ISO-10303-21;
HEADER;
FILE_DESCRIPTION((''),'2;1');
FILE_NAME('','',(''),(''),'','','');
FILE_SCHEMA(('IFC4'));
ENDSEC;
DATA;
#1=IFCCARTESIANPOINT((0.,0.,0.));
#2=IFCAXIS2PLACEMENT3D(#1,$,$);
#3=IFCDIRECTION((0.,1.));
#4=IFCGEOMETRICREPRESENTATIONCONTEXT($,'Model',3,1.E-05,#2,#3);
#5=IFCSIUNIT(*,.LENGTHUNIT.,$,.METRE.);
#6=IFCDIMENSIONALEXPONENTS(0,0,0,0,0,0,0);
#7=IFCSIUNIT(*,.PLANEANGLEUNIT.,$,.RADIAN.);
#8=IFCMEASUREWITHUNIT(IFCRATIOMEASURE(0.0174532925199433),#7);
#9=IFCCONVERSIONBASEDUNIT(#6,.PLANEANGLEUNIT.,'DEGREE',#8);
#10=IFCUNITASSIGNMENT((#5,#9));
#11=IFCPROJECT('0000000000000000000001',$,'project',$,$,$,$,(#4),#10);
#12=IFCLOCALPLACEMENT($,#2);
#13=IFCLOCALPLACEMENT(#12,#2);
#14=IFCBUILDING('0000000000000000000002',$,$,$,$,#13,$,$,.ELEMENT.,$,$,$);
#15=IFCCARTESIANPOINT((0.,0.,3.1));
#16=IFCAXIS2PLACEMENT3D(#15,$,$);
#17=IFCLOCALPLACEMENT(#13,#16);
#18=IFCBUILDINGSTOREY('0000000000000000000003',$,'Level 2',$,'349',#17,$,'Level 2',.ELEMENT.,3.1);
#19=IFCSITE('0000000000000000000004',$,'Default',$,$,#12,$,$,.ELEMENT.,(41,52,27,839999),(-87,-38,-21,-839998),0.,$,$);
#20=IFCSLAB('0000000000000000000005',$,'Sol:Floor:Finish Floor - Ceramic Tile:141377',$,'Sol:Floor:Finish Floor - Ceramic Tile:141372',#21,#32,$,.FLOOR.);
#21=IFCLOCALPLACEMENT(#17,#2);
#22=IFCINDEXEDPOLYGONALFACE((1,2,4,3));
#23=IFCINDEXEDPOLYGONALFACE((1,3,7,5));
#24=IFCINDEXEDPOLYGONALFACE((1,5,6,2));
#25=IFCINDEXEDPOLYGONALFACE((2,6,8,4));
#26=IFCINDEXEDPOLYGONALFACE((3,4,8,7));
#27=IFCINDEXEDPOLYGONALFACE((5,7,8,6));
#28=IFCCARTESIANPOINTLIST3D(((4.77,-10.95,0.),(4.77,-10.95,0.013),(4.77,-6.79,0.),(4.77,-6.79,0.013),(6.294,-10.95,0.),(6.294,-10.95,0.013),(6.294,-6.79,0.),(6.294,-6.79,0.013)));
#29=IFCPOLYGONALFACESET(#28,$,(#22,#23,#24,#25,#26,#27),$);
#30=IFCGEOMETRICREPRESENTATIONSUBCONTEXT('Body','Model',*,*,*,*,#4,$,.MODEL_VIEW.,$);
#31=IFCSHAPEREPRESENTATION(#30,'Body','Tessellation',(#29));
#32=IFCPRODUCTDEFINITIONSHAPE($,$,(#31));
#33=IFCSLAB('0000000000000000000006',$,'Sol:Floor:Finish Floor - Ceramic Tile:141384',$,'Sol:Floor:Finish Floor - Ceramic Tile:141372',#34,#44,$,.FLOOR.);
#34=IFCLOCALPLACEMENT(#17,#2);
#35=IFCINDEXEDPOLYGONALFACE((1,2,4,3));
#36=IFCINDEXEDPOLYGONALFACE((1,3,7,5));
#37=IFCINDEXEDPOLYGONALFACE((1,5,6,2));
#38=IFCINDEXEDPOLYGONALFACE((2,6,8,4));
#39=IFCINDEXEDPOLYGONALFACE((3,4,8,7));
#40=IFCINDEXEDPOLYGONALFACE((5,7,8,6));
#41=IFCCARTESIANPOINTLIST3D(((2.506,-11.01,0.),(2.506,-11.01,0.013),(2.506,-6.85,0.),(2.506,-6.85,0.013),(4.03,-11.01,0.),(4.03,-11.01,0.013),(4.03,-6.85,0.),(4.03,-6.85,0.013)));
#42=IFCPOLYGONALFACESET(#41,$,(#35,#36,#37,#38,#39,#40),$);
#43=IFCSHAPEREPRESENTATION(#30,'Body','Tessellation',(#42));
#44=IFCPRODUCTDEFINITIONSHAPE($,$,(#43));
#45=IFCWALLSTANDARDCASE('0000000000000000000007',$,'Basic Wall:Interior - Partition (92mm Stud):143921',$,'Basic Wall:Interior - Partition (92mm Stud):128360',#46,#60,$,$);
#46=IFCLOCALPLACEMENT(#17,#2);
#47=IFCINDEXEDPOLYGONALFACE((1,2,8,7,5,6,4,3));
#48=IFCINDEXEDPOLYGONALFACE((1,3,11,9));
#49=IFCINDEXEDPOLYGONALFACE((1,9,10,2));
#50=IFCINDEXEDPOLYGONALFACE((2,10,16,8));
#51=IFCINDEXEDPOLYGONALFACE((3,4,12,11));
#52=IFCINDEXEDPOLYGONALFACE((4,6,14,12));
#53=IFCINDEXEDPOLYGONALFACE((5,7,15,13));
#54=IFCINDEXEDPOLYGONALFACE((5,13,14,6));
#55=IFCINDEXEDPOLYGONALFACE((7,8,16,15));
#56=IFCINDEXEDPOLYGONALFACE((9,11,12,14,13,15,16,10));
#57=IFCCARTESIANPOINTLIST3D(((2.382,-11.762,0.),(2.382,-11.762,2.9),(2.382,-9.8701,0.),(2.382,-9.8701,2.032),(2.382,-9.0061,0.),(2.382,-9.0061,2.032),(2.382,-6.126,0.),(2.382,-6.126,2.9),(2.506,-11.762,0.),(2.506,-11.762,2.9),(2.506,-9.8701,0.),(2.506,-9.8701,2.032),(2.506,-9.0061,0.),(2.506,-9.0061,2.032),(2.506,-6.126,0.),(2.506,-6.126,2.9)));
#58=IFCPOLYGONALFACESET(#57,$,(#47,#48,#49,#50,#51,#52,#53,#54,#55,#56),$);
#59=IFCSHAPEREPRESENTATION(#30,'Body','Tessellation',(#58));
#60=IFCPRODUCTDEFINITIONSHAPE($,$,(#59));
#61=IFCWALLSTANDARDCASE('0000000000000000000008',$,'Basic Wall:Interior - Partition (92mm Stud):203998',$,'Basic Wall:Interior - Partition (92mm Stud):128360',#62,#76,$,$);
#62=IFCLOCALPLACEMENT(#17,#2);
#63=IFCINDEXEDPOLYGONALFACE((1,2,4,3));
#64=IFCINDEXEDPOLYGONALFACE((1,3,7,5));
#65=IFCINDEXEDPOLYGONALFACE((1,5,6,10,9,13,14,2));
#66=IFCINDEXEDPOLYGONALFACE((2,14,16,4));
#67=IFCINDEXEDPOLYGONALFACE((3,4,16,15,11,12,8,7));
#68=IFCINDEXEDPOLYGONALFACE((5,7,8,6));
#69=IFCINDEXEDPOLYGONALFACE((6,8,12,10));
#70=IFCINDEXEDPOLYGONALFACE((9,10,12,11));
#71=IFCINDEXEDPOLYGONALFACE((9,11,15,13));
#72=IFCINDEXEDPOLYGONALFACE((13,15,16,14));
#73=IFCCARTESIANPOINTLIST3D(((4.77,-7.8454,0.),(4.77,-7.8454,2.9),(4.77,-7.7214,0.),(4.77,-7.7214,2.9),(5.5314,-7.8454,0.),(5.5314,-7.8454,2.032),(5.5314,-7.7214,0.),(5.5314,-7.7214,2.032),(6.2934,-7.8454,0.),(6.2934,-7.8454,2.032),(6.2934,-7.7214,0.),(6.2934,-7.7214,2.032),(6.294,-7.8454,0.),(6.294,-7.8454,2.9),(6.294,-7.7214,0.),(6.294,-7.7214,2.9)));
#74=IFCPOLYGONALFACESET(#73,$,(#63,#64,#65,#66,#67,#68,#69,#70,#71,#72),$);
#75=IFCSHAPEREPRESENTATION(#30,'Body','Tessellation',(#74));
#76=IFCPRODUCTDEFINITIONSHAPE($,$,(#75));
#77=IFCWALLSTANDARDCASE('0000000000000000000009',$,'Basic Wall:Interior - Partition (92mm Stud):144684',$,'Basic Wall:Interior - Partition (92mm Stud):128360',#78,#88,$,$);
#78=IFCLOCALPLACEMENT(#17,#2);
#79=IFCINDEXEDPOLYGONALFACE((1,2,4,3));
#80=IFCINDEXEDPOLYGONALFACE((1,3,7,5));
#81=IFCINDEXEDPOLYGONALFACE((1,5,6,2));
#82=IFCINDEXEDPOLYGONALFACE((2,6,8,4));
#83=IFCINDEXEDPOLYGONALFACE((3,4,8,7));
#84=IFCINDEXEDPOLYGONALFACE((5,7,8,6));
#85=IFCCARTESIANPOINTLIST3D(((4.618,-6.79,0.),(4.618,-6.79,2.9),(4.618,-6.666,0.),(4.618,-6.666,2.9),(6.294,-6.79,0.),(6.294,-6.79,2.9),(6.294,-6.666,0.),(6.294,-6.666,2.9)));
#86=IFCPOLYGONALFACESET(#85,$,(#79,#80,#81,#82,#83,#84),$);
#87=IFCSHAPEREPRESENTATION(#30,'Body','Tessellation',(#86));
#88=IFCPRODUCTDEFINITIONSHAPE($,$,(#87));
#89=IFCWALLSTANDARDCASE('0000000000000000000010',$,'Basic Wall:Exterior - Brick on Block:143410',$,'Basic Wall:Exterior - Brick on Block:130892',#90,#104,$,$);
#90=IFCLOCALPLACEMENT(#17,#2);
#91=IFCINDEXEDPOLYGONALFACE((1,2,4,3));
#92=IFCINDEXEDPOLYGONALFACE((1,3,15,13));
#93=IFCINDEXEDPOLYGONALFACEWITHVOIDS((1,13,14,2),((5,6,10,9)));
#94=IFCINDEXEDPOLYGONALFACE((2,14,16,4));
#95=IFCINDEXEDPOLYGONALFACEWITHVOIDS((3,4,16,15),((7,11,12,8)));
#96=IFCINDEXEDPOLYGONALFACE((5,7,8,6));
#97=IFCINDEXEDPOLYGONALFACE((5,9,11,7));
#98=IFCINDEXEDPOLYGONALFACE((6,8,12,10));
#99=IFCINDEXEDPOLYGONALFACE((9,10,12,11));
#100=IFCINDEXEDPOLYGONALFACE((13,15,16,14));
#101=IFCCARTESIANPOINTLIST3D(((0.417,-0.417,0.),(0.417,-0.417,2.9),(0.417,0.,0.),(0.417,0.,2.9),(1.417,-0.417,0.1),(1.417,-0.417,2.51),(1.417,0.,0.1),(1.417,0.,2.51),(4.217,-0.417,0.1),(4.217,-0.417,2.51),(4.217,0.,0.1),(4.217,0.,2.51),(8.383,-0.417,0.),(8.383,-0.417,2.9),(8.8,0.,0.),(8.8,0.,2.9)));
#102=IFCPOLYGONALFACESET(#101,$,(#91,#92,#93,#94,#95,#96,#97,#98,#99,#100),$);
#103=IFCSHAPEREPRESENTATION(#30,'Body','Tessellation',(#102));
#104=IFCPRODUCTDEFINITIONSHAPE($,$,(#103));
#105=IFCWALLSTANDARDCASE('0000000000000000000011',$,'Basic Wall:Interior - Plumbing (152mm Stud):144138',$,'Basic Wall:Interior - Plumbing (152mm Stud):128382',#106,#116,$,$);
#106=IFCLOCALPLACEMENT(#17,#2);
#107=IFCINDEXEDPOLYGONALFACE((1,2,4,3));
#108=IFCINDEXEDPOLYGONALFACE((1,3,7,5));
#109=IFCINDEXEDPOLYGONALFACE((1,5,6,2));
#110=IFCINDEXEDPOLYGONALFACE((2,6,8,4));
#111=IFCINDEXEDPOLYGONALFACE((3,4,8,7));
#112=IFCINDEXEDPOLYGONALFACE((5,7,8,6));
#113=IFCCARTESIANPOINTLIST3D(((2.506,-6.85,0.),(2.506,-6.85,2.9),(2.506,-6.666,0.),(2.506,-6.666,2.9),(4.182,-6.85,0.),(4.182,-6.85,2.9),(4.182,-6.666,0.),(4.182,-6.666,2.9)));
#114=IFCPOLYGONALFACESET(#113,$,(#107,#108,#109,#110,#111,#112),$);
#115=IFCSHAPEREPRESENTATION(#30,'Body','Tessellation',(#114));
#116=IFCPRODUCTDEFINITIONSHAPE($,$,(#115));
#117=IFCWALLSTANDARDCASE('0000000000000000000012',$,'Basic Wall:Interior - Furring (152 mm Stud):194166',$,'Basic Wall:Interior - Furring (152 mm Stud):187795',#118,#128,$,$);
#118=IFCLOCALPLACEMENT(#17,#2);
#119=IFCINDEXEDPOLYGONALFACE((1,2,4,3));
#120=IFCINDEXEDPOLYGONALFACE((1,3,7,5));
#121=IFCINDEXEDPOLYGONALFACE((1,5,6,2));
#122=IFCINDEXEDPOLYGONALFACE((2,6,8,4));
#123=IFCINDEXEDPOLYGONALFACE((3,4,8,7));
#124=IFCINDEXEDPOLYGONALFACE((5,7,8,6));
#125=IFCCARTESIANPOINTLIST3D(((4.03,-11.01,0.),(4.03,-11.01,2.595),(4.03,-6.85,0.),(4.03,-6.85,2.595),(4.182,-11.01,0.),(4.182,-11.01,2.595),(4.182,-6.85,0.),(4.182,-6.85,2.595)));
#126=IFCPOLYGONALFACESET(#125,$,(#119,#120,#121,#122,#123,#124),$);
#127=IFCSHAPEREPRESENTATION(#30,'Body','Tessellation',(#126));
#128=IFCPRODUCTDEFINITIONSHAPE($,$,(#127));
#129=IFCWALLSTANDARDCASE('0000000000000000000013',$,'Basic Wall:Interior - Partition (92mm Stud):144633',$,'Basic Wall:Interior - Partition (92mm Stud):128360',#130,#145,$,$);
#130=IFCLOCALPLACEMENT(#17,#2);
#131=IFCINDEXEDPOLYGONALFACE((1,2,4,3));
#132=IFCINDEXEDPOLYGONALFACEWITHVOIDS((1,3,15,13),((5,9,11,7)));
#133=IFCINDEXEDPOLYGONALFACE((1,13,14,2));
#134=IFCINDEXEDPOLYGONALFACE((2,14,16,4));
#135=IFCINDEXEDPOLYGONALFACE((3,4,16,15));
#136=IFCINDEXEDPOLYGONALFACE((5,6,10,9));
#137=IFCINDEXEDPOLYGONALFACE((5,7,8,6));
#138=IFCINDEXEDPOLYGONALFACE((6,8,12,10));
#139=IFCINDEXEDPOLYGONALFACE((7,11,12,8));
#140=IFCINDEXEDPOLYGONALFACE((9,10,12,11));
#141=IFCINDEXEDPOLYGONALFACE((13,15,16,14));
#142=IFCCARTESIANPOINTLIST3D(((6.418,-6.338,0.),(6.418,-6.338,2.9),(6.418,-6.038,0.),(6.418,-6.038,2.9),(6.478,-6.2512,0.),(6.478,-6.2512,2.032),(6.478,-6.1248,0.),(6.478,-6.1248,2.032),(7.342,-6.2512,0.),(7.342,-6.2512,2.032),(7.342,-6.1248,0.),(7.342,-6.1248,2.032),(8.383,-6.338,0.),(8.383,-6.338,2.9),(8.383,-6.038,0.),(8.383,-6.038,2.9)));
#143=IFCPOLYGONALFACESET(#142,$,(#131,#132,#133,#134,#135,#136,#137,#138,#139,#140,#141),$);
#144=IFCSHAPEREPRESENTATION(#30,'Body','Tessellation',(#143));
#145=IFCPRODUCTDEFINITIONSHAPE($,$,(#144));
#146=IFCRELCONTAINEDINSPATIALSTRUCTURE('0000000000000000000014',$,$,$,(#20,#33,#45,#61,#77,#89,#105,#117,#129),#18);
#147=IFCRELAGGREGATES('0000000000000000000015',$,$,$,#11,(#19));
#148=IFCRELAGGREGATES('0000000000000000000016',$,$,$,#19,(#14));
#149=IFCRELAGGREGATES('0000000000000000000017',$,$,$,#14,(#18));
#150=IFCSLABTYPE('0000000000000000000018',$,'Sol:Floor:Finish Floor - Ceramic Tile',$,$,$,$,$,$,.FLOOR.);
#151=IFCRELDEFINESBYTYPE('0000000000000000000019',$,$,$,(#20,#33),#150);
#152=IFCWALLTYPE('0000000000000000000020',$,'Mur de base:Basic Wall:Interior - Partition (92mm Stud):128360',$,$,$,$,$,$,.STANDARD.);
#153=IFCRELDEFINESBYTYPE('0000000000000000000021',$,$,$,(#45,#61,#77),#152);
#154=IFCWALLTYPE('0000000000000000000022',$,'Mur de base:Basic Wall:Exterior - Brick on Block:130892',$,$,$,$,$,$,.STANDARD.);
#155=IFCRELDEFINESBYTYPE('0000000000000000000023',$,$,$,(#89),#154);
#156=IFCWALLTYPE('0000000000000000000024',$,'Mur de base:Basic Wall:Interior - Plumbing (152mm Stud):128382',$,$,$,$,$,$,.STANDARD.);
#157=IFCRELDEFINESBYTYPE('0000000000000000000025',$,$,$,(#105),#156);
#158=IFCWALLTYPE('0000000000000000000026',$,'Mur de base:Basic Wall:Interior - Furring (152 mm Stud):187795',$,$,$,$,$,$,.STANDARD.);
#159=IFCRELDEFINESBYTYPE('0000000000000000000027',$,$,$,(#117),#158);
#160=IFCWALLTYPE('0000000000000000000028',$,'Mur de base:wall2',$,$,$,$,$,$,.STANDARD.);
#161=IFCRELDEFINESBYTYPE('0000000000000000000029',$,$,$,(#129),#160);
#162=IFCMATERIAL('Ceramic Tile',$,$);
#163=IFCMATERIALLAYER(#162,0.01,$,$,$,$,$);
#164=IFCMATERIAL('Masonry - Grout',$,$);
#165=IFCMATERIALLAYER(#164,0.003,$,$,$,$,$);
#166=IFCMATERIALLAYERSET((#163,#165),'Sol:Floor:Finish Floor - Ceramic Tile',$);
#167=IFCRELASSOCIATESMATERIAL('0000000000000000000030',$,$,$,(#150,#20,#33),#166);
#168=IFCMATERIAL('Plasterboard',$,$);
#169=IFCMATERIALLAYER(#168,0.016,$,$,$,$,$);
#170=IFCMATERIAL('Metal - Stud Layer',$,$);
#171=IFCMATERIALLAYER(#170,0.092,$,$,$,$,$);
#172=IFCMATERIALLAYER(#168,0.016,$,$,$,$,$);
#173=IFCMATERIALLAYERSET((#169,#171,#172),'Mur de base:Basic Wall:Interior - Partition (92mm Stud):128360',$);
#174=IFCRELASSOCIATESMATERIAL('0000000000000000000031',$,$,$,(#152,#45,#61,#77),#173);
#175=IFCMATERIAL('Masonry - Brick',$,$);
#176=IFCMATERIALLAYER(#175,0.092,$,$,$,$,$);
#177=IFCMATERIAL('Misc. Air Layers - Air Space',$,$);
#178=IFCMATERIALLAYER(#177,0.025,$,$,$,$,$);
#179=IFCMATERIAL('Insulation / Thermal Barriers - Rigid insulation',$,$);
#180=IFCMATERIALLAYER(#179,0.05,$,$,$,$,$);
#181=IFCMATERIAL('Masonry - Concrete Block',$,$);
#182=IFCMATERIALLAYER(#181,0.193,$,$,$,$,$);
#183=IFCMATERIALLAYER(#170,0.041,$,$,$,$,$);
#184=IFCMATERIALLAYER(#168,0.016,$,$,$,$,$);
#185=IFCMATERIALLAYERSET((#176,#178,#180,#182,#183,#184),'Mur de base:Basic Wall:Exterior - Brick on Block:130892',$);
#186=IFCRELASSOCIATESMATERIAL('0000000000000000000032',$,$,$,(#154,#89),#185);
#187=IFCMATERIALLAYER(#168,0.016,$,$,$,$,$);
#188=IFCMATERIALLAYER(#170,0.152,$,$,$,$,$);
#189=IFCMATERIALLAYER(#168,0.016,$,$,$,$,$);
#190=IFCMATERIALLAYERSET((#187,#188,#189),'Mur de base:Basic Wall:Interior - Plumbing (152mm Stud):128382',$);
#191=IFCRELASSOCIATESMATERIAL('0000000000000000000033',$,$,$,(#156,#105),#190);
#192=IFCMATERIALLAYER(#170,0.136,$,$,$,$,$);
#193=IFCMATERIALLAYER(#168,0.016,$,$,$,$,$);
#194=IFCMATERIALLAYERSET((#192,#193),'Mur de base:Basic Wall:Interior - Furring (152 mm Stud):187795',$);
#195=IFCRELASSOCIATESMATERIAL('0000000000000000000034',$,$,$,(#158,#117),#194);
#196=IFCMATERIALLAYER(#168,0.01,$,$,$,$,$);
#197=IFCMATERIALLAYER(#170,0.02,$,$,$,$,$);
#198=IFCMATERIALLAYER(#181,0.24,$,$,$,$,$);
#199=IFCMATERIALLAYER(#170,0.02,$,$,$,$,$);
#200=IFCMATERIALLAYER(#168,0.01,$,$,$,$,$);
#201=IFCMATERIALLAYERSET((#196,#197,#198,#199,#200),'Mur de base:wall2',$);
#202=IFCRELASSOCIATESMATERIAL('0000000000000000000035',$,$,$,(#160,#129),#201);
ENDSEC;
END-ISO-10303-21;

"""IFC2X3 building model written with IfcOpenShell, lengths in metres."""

from ifc_helpers import new_model, entity, si_unit, converted_unit, direction, frame, frame_2d, origin, origin_2d_with_axis, place, context, subcontext, project, spatial, polyline, rectangle, outline, extrude, material, layer, layer_set, layer_usage, type_object, element, save


model = new_model("IFC2X3")

# Units and contexts
model_context = context("Model", 3, precision=1e-05, world=origin(), true_north=direction((0.0, 1.0)))
body_context = subcontext(model_context, "Body", "Model", "MODEL_VIEW")
ifc_project = project(units=[si_unit("LENGTHUNIT", "METRE"), converted_unit("PLANEANGLEUNIT", "DEGREE", entity("IfcRatioMeasure", 0.0174532925199433), si_unit("PLANEANGLEUNIT", "RADIAN"), dimensions=[0, 0, 0, 0, 0, 0, 0])], contexts=[model_context])

# Site, building, storey
site_placement = place(None, origin())
site = spatial("IfcSite", under=ifc_project, at=site_placement, Name="Default", CompositionType="ELEMENT", RefLatitude=(41, 52, 27, 839999), RefLongitude=(-87, -38, -21, -839998), RefElevation=0.0)
building_placement = place(site_placement, origin())
building = spatial("IfcBuilding", under=site, at=building_placement, CompositionType="ELEMENT")
storey_placement = place(building_placement, frame((0.0, 0.0, 3.1)))
storey = spatial("IfcBuildingStorey", under=building, at=storey_placement, Name="Level 2", ObjectType="349", LongName="Level 2", CompositionType="ELEMENT", Elevation=3.1)

# Slabs
ifc_material_1 = material(Name="Ceramic Tile")
ifc_layer_1 = layer(ifc_material_1, 0.01)
ifc_material_2 = material(Name="Masonry - Grout")
ifc_layer_2 = layer(ifc_material_2, 0.003)
ifc_layer_set_1 = layer_set([ifc_layer_1, ifc_layer_2], Name="Sol:Floor:Finish Floor - Ceramic Tile")
ifc_layer_usage_1 = layer_usage(ifc_layer_set_1, "AXIS3", "POSITIVE", 0.0)
slab_type = type_object("IfcSlabType", Name="Sol:Floor:Finish Floor - Ceramic Tile", PredefinedType="FLOOR", material=ifc_layer_set_1)
slab_1_placement = place(storey_placement, origin())
element("IfcSlab", 1, at=slab_1_placement, inside=storey, type_object=slab_type, material=ifc_layer_usage_1, Name="Sol:Floor:Finish Floor - Ceramic Tile:141377", ObjectType="Sol:Floor:Finish Floor - Ceramic Tile:141372", PredefinedType="FLOOR", context=body_context, shape_type="SweptSolid", body=[
    extrude(rectangle(XDim=4.16, YDim=1.524, at=frame_2d((0.0, 0.0), x_axis=(1.0, 0.0))), frame((5.532, -8.87, 0.013), z_axis=(0.0, 0.0, -1.0), x_axis=(0.0, 1.0, 0.0)), (0.0, 0.0, 1.0), 0.013),
])
ifc_layer_usage_2 = layer_usage(ifc_layer_set_1, "AXIS3", "POSITIVE", 0.0)
slab_2_placement = place(storey_placement, origin())
element("IfcSlab", 2, at=slab_2_placement, inside=storey, type_object=slab_type, material=ifc_layer_usage_2, Name="Sol:Floor:Finish Floor - Ceramic Tile:141384", ObjectType="Sol:Floor:Finish Floor - Ceramic Tile:141372", PredefinedType="FLOOR", context=body_context, shape_type="SweptSolid", body=[
    extrude(rectangle(XDim=4.16, YDim=1.524, at=origin_2d_with_axis()), frame((3.268, -8.93, 0.013), z_axis=(0.0, 0.0, -1.0), x_axis=(0.0, 1.0, 0.0)), (0.0, 0.0, 1.0), 0.013),
])

# Walls, openings
ifc_material_3 = material(Name="Plasterboard")
ifc_layer_3 = layer(ifc_material_3, 0.016)
ifc_material_4 = material(Name="Metal - Stud Layer")
ifc_layer_4 = layer(ifc_material_4, 0.092)
ifc_layer_5 = layer(ifc_material_3, 0.016)
ifc_layer_set_2 = layer_set([ifc_layer_3, ifc_layer_4, ifc_layer_5], Name="Mur de base:Basic Wall:Interior - Partition (92mm Stud):128360")
ifc_layer_usage_3 = layer_usage(ifc_layer_set_2, "AXIS2", "NEGATIVE", 0.062)
wall_type_1 = type_object("IfcWallType", Name="Mur de base:Basic Wall:Interior - Partition (92mm Stud):128360", PredefinedType="STANDARD", material=ifc_layer_set_2)
wall_1_placement = place(storey_placement, frame((2.444, -6.126, 0.0), z_axis=(0.0, 0.0, 1.0), x_axis=(0.0, -1.0, 0.0)))
wall_1 = element("IfcWallStandardCase", 3, at=wall_1_placement, inside=storey, type_object=wall_type_1, material=ifc_layer_usage_3, Name="Basic Wall:Interior - Partition (92mm Stud):143921", ObjectType="Basic Wall:Interior - Partition (92mm Stud):128360", context=body_context, shape_type="SweptSolid", body=[
    extrude(rectangle(XDim=5.636, YDim=0.124, at=frame_2d((2.818, 0.0), x_axis=(-1.0, 0.0))), origin(), (0.0, 0.0, 1.0), 2.9),
])
opening_1_placement = place(wall_1_placement, origin())
element("IfcOpeningElement", 4, at=opening_1_placement, cuts=wall_1, ObjectType="Opening", context=body_context, shape_type="SweptSolid", body=[
    extrude(rectangle(XDim=2.032, YDim=0.864, at=frame_2d((0.0, 0.0), x_axis=(1.0, 0.0))), frame((3.3121, -0.0632, 1.016), z_axis=(0.0, 1.0, 0.0), x_axis=(0.0, 0.0, -1.0)), (0.0, 0.0, 1.0), 0.1265),
])
ifc_layer_usage_4 = layer_usage(ifc_layer_set_2, "AXIS2", "NEGATIVE", 0.062)
wall_2_placement = place(storey_placement, frame((6.294, -7.7834, 0.0), z_axis=(0.0, 0.0, 1.0), x_axis=(-1.0, 0.0, 0.0)))
wall_2 = element("IfcWallStandardCase", 5, at=wall_2_placement, inside=storey, type_object=wall_type_1, material=ifc_layer_usage_4, Name="Basic Wall:Interior - Partition (92mm Stud):203998", ObjectType="Basic Wall:Interior - Partition (92mm Stud):128360", context=body_context, shape_type="SweptSolid", body=[
    extrude(rectangle(XDim=1.524, YDim=0.124, at=frame_2d((0.762, 0.0), x_axis=(-1.0, 0.0))), origin(), (0.0, 0.0, 1.0), 2.9),
])
opening_2_placement = place(wall_2_placement, origin())
element("IfcOpeningElement", 6, at=opening_2_placement, cuts=wall_2, ObjectType="Opening", context=body_context, shape_type="SweptSolid", body=[
    extrude(rectangle(XDim=2.032, YDim=0.762, at=frame_2d((0.0, 0.0), x_axis=(0.0, 1.0))), frame((0.3816, -0.0632, 1.016), z_axis=(0.0, 1.0, 0.0), x_axis=(1.0, 0.0, 0.0)), (0.0, 0.0, 1.0), 0.1265),
])

# Wall
ifc_layer_usage_5 = layer_usage(ifc_layer_set_2, "AXIS2", "NEGATIVE", 0.062)
wall_3_placement = place(storey_placement, frame((4.618, -6.728, 0.0)))
element("IfcWallStandardCase", 7, at=wall_3_placement, inside=storey, type_object=wall_type_1, material=ifc_layer_usage_5, Name="Basic Wall:Interior - Partition (92mm Stud):144684", ObjectType="Basic Wall:Interior - Partition (92mm Stud):128360", context=body_context, shape_type="SweptSolid", body=[
    extrude(rectangle(XDim=1.676, YDim=0.124, at=frame_2d((0.838, 0.0), x_axis=(-1.0, 0.0))), origin(), (0.0, 0.0, 1.0), 2.9),
])

# Shared definitions
ifc_material_5 = material(Name="Masonry - Brick")
ifc_layer_6 = layer(ifc_material_5, 0.092)
ifc_material_6 = material(Name="Misc. Air Layers - Air Space")
ifc_layer_7 = layer(ifc_material_6, 0.025)
ifc_material_7 = material(Name="Insulation / Thermal Barriers - Rigid insulation")
ifc_layer_8 = layer(ifc_material_7, 0.05)
ifc_material_8 = material(Name="Masonry - Concrete Block")
ifc_layer_9 = layer(ifc_material_8, 0.193)
ifc_layer_10 = layer(ifc_material_4, 0.041)
ifc_layer_11 = layer(ifc_material_3, 0.016)
ifc_layer_set_3 = layer_set([ifc_layer_6, ifc_layer_7, ifc_layer_8, ifc_layer_9, ifc_layer_10, ifc_layer_11], Name="Mur de base:Basic Wall:Exterior - Brick on Block:130892")
wall_type_2 = type_object("IfcWallType", Name="Mur de base:Basic Wall:Exterior - Brick on Block:130892", PredefinedType="STANDARD", material=ifc_layer_set_3)

# Wall, opening
ifc_layer_usage_6 = layer_usage(ifc_layer_set_3, "AXIS2", "NEGATIVE", 0.2085)
wall_4_placement = place(storey_placement, frame((0.417, -0.2085, 0.0)))
wall_4 = element("IfcWallStandardCase", 8, at=wall_4_placement, inside=storey, type_object=wall_type_2, material=ifc_layer_usage_6, Name="Basic Wall:Exterior - Brick on Block:143410", ObjectType="Basic Wall:Exterior - Brick on Block:130892", context=body_context, shape_type="SweptSolid", body=[
    extrude(outline(polyline([(7.966, -0.2085), (8.383, 0.2085), (0.0, 0.2085), (0.0, -0.2085), (7.966, -0.2085)])), origin(), (0.0, 0.0, 1.0), 2.9),
])
opening_3_placement = place(wall_4_placement, origin())
element("IfcOpeningElement", 9, at=opening_3_placement, cuts=wall_4, ObjectType="Opening", context=body_context, shape_type="SweptSolid", body=[
    extrude(rectangle(XDim=2.41, YDim=2.8, at=frame_2d((0.0, 0.0), x_axis=(0.0, 1.0))), frame((2.4, -0.2127, 1.305), z_axis=(0.0, 1.0, 0.0), x_axis=(1.0, 0.0, 0.0)), (0.0, 0.0, 1.0), 0.4253),
])

# Walls
ifc_layer_12 = layer(ifc_material_3, 0.016)
ifc_layer_13 = layer(ifc_material_4, 0.152)
ifc_layer_14 = layer(ifc_material_3, 0.016)
ifc_layer_set_4 = layer_set([ifc_layer_12, ifc_layer_13, ifc_layer_14], Name="Mur de base:Basic Wall:Interior - Plumbing (152mm Stud):128382")
ifc_layer_usage_7 = layer_usage(ifc_layer_set_4, "AXIS2", "NEGATIVE", 0.092)
wall_type_3 = type_object("IfcWallType", Name="Mur de base:Basic Wall:Interior - Plumbing (152mm Stud):128382", PredefinedType="STANDARD", material=ifc_layer_set_4)
wall_5_placement = place(storey_placement, frame((2.506, -6.758, 0.0)))
element("IfcWallStandardCase", 10, at=wall_5_placement, inside=storey, type_object=wall_type_3, material=ifc_layer_usage_7, Name="Basic Wall:Interior - Plumbing (152mm Stud):144138", ObjectType="Basic Wall:Interior - Plumbing (152mm Stud):128382", context=body_context, shape_type="SweptSolid", body=[
    extrude(rectangle(XDim=1.676, YDim=0.184, at=frame_2d((0.838, 0.0), x_axis=(-1.0, 0.0))), origin(), (0.0, 0.0, 1.0), 2.9),
])
ifc_layer_15 = layer(ifc_material_4, 0.136)
ifc_layer_16 = layer(ifc_material_3, 0.016)
ifc_layer_set_5 = layer_set([ifc_layer_15, ifc_layer_16], Name="Mur de base:Basic Wall:Interior - Furring (152 mm Stud):187795")
ifc_layer_usage_8 = layer_usage(ifc_layer_set_5, "AXIS2", "NEGATIVE", 0.076)
wall_type_4 = type_object("IfcWallType", Name="Mur de base:Basic Wall:Interior - Furring (152 mm Stud):187795", PredefinedType="STANDARD", material=ifc_layer_set_5)
wall_6_placement = place(storey_placement, frame((4.106, -6.85, 0.0), z_axis=(0.0, 0.0, 1.0), x_axis=(0.0, -1.0, 0.0)))
element("IfcWallStandardCase", 11, at=wall_6_placement, inside=storey, type_object=wall_type_4, material=ifc_layer_usage_8, Name="Basic Wall:Interior - Furring (152 mm Stud):194166", ObjectType="Basic Wall:Interior - Furring (152 mm Stud):187795", context=body_context, shape_type="SweptSolid", body=[
    extrude(rectangle(XDim=4.16, YDim=0.152, at=frame_2d((2.08, 0.0), x_axis=(-1.0, 0.0))), origin(), (0.0, 0.0, 1.0), 2.595),
])

# Wall, opening
ifc_layer_17 = layer(ifc_material_3, 0.01)
ifc_layer_18 = layer(ifc_material_4, 0.02)
ifc_layer_19 = layer(ifc_material_8, 0.24)
ifc_layer_20 = layer(ifc_material_4, 0.02)
ifc_layer_21 = layer(ifc_material_3, 0.01)
ifc_layer_set_6 = layer_set([ifc_layer_17, ifc_layer_18, ifc_layer_19, ifc_layer_20, ifc_layer_21], Name="Mur de base:wall2")
ifc_layer_usage_9 = layer_usage(ifc_layer_set_6, "AXIS2", "NEGATIVE", 0.15)
wall_type_5 = type_object("IfcWallType", Name="Mur de base:wall2", PredefinedType="STANDARD", material=ifc_layer_set_6)
wall_7_placement = place(storey_placement, frame((6.418, -6.188, 0.0)))
wall_7 = element("IfcWallStandardCase", 12, at=wall_7_placement, inside=storey, type_object=wall_type_5, material=ifc_layer_usage_9, Name="Basic Wall:Interior - Partition (92mm Stud):144633", ObjectType="Basic Wall:Interior - Partition (92mm Stud):128360", context=body_context, shape_type="SweptSolid", body=[
    extrude(rectangle(XDim=1.965, YDim=0.3, at=frame_2d((0.9825, 0.0), x_axis=(-1.0, 0.0))), origin(), (0.0, 0.0, 1.0), 2.9),
])
opening_4_placement = place(wall_7_placement, origin())
element("IfcOpeningElement", 13, at=opening_4_placement, cuts=wall_7, ObjectType="Recess", context=body_context, shape_type="SweptSolid", body=[
    extrude(rectangle(XDim=2.032, YDim=0.864, at=frame_2d((0.0, 0.0), x_axis=(1.0, 0.0))), frame((0.492, -0.0632, 1.016), z_axis=(0.0, 1.0, 0.0), x_axis=(0.0, 0.0, 1.0)), (0.0, 0.0, 1.0), 0.1265),
])

save(model, "model.ifc")
